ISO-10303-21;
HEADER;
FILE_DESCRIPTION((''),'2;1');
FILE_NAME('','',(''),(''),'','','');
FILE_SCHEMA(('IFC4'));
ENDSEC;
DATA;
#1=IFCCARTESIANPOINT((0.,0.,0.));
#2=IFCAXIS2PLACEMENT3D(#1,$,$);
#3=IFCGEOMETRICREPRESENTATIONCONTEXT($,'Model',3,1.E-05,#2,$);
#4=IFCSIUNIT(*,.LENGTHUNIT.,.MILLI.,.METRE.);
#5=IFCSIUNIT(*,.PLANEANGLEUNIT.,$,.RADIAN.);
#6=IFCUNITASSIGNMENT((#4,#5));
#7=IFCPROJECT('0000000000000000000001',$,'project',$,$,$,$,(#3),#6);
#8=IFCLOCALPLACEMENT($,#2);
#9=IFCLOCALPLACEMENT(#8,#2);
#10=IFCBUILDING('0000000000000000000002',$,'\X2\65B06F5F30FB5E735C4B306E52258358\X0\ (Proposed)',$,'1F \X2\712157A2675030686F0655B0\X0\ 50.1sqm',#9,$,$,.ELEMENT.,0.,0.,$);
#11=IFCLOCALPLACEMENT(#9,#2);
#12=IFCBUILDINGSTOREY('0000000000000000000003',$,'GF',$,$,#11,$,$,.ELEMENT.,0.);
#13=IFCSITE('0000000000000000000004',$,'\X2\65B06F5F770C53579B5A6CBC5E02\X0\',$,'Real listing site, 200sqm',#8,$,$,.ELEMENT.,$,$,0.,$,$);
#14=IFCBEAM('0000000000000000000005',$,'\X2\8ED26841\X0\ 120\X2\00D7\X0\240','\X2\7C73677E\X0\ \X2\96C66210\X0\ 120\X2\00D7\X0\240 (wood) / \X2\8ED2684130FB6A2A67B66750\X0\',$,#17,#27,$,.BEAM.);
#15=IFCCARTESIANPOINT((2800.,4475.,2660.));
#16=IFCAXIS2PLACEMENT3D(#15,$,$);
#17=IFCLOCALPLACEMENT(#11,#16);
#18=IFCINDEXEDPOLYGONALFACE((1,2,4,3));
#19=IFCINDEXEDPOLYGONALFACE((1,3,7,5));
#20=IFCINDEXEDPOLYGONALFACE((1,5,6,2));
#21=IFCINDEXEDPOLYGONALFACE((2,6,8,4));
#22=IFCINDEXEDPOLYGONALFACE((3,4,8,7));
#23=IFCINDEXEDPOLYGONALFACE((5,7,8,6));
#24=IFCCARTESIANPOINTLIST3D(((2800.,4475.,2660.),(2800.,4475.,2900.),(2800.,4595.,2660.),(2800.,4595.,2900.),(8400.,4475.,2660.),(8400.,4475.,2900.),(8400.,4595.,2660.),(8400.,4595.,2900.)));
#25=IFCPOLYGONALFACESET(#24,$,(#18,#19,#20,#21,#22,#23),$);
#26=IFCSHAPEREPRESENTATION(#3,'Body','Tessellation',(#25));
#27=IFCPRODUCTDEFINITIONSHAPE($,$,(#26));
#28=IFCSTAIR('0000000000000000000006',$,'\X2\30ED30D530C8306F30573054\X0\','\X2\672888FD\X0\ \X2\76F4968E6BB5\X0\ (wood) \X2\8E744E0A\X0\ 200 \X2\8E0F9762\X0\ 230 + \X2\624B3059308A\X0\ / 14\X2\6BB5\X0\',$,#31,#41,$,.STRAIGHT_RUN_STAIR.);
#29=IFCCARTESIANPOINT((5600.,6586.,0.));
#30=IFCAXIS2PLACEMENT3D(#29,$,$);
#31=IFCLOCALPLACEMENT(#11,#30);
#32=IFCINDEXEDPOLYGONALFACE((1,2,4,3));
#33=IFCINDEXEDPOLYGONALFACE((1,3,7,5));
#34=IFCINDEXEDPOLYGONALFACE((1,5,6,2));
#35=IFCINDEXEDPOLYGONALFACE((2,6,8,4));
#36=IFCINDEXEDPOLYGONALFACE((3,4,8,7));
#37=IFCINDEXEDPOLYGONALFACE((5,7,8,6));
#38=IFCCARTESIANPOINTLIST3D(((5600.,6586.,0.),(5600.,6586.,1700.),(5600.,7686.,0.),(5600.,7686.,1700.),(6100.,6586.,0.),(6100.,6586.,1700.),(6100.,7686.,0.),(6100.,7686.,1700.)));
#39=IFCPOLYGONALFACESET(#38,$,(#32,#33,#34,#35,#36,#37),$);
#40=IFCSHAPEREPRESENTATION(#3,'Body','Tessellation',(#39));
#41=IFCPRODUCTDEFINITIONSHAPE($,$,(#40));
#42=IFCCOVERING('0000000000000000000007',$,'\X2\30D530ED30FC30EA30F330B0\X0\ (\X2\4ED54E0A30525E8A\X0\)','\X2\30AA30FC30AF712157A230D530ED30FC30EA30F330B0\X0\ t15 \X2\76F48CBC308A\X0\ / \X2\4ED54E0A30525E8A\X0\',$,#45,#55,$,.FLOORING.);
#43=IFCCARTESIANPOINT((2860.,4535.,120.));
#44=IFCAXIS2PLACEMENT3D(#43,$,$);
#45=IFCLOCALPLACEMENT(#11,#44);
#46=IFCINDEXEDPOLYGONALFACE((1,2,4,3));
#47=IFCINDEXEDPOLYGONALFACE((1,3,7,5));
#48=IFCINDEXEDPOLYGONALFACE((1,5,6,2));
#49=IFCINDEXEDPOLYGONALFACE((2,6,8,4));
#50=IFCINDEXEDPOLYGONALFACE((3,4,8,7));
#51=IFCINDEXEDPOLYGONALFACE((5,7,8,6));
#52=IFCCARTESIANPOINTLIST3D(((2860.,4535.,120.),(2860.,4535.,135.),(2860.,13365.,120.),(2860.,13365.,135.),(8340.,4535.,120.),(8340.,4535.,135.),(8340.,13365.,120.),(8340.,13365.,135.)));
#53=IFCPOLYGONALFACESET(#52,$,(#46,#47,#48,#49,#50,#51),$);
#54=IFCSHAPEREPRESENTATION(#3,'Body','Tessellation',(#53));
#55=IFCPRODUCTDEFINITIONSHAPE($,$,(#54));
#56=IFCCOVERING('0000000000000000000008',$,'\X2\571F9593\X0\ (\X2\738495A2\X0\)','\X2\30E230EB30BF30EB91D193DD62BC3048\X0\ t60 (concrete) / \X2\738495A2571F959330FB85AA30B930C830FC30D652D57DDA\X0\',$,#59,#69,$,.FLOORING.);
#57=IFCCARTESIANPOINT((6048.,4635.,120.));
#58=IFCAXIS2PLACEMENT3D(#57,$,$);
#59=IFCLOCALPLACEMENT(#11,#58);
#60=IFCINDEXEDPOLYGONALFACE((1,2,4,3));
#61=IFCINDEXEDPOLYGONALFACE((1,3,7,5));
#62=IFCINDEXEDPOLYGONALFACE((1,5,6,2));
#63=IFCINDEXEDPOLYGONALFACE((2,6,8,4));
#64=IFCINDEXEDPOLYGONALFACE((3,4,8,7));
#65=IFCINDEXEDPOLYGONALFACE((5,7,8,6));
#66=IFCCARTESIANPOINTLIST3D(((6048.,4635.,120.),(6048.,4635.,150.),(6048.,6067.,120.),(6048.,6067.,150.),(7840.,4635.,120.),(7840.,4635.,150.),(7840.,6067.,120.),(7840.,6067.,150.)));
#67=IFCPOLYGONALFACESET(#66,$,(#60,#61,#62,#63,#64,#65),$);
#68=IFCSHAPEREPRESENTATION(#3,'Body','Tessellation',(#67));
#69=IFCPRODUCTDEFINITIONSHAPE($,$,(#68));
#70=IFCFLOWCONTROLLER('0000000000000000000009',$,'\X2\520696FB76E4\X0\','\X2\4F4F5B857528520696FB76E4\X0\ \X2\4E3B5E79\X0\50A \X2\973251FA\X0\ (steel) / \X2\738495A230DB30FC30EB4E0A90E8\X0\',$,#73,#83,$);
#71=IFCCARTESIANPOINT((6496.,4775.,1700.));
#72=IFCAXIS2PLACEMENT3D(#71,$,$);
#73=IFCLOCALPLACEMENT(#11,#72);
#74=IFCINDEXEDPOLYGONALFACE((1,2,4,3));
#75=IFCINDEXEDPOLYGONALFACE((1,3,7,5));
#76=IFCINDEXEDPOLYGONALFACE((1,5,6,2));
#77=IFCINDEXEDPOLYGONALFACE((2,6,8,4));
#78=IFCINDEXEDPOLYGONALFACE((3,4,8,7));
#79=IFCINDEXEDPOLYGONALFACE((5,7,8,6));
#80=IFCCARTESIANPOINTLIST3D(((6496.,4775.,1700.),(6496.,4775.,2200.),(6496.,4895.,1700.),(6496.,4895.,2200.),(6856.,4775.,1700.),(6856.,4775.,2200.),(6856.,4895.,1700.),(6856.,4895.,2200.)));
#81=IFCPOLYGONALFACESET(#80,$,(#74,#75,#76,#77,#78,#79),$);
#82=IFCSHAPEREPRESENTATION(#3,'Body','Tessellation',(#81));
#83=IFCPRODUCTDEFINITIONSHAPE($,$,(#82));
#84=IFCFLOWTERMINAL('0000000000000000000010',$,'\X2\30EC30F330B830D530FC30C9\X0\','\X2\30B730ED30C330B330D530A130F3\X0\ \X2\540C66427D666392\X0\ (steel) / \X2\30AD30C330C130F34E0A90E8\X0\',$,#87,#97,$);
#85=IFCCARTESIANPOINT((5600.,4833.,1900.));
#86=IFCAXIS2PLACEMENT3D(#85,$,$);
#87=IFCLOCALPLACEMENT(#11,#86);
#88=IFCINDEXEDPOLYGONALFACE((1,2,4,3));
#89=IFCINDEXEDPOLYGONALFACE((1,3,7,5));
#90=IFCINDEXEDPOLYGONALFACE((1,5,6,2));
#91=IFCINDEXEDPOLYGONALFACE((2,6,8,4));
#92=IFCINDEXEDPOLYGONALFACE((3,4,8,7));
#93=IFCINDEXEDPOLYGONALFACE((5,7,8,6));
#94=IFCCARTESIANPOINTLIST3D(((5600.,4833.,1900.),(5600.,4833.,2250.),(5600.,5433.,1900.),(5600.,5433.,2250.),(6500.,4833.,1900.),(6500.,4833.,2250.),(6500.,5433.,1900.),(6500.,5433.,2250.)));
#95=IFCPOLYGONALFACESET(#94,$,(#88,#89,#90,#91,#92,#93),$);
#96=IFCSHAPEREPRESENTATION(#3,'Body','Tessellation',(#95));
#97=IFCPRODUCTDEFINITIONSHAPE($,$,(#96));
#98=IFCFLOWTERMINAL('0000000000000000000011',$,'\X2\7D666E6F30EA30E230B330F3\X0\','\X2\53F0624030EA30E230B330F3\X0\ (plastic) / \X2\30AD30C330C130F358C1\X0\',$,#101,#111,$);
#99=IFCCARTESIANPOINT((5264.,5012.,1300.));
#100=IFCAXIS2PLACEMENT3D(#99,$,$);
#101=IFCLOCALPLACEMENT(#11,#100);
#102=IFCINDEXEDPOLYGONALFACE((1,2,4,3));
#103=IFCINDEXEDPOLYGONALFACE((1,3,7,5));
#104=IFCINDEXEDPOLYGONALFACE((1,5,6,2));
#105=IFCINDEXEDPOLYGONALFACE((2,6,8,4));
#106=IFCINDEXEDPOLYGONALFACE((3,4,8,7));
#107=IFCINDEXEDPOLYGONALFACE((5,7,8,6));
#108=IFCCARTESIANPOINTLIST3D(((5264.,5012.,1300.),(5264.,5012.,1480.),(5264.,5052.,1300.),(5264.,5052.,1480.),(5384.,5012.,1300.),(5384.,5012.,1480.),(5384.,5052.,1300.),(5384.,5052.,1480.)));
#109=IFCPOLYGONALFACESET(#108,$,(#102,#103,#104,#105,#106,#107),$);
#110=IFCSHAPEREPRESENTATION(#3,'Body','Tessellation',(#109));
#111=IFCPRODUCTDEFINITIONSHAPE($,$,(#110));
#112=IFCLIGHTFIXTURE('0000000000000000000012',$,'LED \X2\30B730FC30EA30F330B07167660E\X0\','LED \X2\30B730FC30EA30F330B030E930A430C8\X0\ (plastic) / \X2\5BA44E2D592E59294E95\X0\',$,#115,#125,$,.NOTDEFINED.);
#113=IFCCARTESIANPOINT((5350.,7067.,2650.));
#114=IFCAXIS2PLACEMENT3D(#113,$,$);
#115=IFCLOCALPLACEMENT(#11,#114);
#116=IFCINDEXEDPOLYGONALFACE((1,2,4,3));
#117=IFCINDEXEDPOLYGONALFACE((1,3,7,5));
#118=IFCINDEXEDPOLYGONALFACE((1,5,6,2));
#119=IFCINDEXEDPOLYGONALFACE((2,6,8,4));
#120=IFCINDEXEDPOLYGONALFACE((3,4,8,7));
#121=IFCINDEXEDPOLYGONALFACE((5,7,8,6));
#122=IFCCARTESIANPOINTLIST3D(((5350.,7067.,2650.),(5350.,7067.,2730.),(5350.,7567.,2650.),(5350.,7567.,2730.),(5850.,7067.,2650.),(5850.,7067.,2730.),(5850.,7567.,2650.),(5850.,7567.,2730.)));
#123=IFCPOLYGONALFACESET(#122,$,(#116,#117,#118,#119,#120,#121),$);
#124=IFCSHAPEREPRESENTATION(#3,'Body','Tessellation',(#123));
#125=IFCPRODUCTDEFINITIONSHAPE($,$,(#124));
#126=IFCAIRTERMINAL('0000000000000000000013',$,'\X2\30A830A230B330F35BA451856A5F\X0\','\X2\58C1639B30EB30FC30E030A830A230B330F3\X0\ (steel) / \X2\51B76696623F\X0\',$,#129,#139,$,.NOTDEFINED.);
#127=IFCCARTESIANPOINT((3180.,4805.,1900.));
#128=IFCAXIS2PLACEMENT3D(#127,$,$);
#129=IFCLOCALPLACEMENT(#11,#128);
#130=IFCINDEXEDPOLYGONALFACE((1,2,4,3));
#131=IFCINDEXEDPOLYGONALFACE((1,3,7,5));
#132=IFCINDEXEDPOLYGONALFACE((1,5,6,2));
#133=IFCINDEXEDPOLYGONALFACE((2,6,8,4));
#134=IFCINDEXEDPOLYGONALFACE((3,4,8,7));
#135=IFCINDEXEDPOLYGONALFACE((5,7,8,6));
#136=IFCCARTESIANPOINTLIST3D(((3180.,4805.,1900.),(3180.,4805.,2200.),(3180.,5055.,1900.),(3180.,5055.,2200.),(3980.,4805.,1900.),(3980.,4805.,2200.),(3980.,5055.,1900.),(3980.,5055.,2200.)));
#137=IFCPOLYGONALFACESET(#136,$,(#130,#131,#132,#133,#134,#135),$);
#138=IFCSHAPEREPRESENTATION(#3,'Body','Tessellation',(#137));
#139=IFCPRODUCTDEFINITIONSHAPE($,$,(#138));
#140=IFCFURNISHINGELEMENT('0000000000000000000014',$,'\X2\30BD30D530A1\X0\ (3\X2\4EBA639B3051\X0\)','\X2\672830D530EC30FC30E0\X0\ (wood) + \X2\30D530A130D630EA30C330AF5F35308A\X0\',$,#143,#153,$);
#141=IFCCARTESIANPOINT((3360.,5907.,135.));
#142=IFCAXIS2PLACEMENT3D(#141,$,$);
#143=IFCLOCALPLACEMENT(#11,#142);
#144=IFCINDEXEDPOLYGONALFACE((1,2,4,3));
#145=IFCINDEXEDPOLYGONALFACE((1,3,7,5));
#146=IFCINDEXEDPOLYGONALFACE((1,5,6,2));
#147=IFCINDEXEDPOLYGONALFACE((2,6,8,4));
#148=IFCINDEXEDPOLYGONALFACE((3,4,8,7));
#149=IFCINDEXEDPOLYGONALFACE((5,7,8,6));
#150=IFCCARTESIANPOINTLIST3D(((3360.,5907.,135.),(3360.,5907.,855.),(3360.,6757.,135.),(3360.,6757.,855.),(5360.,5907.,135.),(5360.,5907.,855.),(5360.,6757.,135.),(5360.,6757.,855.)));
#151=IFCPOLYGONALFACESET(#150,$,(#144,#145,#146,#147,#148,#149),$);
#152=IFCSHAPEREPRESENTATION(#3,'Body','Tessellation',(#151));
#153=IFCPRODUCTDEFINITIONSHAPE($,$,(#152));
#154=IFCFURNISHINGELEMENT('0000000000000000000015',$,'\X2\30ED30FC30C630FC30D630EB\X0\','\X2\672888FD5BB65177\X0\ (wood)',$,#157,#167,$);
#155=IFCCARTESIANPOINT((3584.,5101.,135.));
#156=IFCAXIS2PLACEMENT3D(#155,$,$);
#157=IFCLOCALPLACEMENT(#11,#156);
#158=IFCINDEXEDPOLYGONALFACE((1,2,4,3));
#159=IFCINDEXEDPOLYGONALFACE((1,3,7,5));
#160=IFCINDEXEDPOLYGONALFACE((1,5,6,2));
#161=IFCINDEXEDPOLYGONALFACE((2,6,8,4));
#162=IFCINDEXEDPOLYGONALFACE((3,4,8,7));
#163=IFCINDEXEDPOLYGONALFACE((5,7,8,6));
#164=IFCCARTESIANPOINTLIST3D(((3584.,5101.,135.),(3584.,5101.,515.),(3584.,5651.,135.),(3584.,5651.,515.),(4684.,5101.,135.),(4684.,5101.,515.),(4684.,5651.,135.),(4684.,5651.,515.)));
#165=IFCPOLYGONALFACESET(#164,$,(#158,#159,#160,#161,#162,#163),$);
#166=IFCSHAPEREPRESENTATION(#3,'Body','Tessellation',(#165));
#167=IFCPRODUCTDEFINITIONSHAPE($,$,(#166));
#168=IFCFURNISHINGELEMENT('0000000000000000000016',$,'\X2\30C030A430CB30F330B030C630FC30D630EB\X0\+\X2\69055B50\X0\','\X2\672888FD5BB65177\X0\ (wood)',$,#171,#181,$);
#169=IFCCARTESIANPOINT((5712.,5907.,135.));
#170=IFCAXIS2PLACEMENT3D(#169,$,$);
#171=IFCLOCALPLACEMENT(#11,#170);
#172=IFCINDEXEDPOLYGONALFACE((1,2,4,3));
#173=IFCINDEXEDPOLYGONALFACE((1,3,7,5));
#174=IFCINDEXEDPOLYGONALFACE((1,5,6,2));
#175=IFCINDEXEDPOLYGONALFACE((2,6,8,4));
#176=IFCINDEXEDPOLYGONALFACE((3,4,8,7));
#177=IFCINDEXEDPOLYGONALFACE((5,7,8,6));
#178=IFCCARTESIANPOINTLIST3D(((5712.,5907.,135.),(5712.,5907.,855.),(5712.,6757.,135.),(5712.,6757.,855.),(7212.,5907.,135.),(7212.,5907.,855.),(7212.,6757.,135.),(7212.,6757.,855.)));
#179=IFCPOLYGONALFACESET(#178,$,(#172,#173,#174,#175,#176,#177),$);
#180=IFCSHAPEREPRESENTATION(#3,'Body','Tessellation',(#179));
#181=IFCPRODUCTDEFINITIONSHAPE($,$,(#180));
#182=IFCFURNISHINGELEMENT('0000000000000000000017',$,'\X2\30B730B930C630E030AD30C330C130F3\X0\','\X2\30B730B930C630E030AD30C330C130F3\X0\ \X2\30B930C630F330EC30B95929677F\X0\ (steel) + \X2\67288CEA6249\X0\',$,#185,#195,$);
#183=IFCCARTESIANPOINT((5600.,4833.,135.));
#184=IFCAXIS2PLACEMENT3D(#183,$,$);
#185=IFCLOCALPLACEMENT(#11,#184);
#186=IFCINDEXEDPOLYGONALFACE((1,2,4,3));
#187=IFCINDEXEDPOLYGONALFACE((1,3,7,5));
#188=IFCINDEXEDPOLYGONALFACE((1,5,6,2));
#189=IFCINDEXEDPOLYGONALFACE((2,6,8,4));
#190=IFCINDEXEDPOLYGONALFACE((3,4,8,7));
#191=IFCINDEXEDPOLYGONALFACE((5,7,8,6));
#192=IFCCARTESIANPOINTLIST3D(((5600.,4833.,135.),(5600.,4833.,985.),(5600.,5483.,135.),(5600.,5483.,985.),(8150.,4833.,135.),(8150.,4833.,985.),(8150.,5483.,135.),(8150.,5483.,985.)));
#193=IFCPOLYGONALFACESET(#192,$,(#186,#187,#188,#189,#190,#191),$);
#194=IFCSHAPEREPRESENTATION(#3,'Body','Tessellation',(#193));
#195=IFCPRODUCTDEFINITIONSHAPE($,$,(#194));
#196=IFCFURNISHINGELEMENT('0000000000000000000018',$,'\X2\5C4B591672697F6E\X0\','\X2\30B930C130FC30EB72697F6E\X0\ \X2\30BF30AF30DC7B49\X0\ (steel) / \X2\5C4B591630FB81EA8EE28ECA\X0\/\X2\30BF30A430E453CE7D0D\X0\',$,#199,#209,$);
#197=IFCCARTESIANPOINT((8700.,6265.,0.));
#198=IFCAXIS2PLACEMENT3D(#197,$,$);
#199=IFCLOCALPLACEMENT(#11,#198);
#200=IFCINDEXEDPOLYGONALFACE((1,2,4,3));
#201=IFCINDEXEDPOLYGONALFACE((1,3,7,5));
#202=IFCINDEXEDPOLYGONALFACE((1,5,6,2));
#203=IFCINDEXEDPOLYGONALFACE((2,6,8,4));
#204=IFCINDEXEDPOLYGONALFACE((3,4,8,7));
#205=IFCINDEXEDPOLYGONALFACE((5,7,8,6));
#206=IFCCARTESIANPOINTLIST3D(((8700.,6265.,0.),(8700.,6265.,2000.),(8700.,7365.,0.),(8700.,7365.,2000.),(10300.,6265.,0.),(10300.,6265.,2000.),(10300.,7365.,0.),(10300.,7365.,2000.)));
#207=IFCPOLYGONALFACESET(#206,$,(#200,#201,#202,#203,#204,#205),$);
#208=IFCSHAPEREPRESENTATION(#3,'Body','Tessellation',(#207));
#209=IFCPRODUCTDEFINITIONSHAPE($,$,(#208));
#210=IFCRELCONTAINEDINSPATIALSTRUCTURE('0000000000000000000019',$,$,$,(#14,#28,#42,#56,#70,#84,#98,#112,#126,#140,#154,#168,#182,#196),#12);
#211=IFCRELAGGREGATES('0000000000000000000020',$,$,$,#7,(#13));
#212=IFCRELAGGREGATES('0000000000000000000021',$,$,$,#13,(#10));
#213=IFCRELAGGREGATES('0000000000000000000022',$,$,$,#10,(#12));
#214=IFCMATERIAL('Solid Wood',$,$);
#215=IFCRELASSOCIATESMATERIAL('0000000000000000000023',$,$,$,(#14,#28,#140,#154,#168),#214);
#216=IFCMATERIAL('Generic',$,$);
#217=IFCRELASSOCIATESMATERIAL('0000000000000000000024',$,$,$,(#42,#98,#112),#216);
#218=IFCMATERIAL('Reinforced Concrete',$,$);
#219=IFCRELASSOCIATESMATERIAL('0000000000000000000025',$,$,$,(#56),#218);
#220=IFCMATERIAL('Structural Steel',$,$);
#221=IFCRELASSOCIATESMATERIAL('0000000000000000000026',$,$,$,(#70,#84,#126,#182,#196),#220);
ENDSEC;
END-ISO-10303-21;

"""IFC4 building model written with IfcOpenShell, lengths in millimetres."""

from ifc_helpers import new_model, si_unit, frame, frame_2d, origin, place, context, project, spatial, rectangle, extrude, material, element, save


model = new_model("IFC4")

# Units and contexts
model_context = context("Model", 3, precision=1e-05, world=origin())
ifc_project = project(units=[si_unit("LENGTHUNIT", "METRE", prefix="MILLI"), si_unit("PLANEANGLEUNIT", "RADIAN")], contexts=[model_context])

# Site, building, storey
site_placement = place(None, origin())
site = spatial("IfcSite", under=ifc_project, at=site_placement, Name="新潟県南魚沼市", ObjectType="Real listing site, 200sqm", CompositionType="ELEMENT", RefElevation=0.0)
building_placement = place(site_placement, origin())
building = spatial("IfcBuilding", under=site, at=building_placement, Name="新潟・平屋の別荘 (Proposed)", ObjectType="1F 無垢材と漆喰 50.1sqm", CompositionType="ELEMENT", ElevationOfRefHeight=0.0, ElevationOfTerrain=0.0)
storey_placement = place(building_placement, origin())
storey = spatial("IfcBuildingStorey", under=building, at=storey_placement, Name="GF", CompositionType="ELEMENT", Elevation=0.0)

# Beam
ifc_material_1 = material(Name="Solid Wood")
beam_1_placement = place(storey_placement, frame((2800.0, 4475.0, 2660.0)))
element("IfcBeam", 1, at=beam_1_placement, inside=storey, material=ifc_material_1, Name="軒桁 120×240", Description="米松 集成 120×240 (wood) / 軒桁・横架材", PredefinedType="BEAM", context=model_context, shape_type="SweptSolid", body=[
    extrude(rectangle(XDim=5600.0, YDim=120.0, at=frame_2d((2800.0, 60.0))), frame((2800.0, 4475.0, 2660.0)), (0.0, 0.0, 1.0), 240.0),
])

# Stair
stair_placement = place(storey_placement, frame((5600.0, 6586.0, 0.0)))
element("IfcStair", 2, at=stair_placement, inside=storey, material=ifc_material_1, Name="ロフトはしご", Description="木製 直階段 (wood) 蹴上 200 踏面 230 + 手すり / 14段", PredefinedType="STRAIGHT_RUN_STAIR", context=model_context, shape_type="SweptSolid", body=[
    extrude(rectangle(XDim=500.0, YDim=1100.0, at=frame_2d((250.0, 550.0))), frame((5600.0, 6586.0, 0.0)), (0.0, 0.0, 1.0), 1700.0),
])

# Coverings
ifc_material_2 = material(Name="Generic")
covering_1_placement = place(storey_placement, frame((2860.0, 4535.0, 120.0)))
element("IfcCovering", 3, at=covering_1_placement, inside=storey, material=ifc_material_2, Name="フローリング (仕上げ床)", Description="オーク無垢フローリング t15 直貼り / 仕上げ床", PredefinedType="FLOORING", context=model_context, shape_type="SweptSolid", body=[
    extrude(rectangle(XDim=5480.0, YDim=8830.0, at=frame_2d((2740.0, 4415.0))), frame((2860.0, 4535.0, 120.0)), (0.0, 0.0, 1.0), 15.0),
])
ifc_material_3 = material(Name="Reinforced Concrete")
covering_2_placement = place(storey_placement, frame((6048.0, 4635.0, 120.0)))
element("IfcCovering", 4, at=covering_2_placement, inside=storey, material=ifc_material_3, Name="土間 (玄関)", Description="モルタル金鏝押え t60 (concrete) / 玄関土間・薪ストーブ動線", PredefinedType="FLOORING", context=model_context, shape_type="SweptSolid", body=[
    extrude(rectangle(XDim=1792.0, YDim=1432.0, at=frame_2d((896.0, 716.0))), frame((6048.0, 4635.0, 120.0)), (0.0, 0.0, 1.0), 30.0),
])

# Flow controller
ifc_material_4 = material(Name="Structural Steel")
flow_controller_placement = place(storey_placement, frame((6496.0, 4775.0, 1700.0)))
element("IfcFlowController", 5, at=flow_controller_placement, inside=storey, material=ifc_material_4, Name="分電盤", Description="住宅用分電盤 主幹50A 露出 (steel) / 玄関ホール上部", context=model_context, shape_type="SweptSolid", body=[
    extrude(rectangle(XDim=360.0, YDim=120.0, at=frame_2d((180.0, 60.0))), frame((6496.0, 4775.0, 1700.0)), (0.0, 0.0, 1.0), 500.0),
])

# Flow terminals
flow_terminal_1_placement = place(storey_placement, frame((5600.0, 4833.0, 1900.0)))
element("IfcFlowTerminal", 6, at=flow_terminal_1_placement, inside=storey, material=ifc_material_4, Name="レンジフード", Description="シロッコファン 同時給排 (steel) / キッチン上部", context=model_context, shape_type="SweptSolid", body=[
    extrude(rectangle(XDim=900.0, YDim=600.0, at=frame_2d((450.0, 300.0))), frame((5600.0, 4833.0, 1900.0)), (0.0, 0.0, 1.0), 350.0),
])
flow_terminal_2_placement = place(storey_placement, frame((5264.0, 5012.0, 1300.0)))
element("IfcFlowTerminal", 7, at=flow_terminal_2_placement, inside=storey, material=ifc_material_2, Name="給湯リモコン", Description="台所リモコン (plastic) / キッチン壁", context=model_context, shape_type="SweptSolid", body=[
    extrude(rectangle(XDim=120.0, YDim=40.0, at=frame_2d((60.0, 20.0))), frame((5264.0, 5012.0, 1300.0)), (0.0, 0.0, 1.0), 180.0),
])

# Light fixture
light_fixture_placement = place(storey_placement, frame((5350.0, 7067.0, 2650.0)))
element("IfcLightFixture", 8, at=light_fixture_placement, inside=storey, material=ifc_material_2, Name="LED シーリング照明", Description="LED シーリングライト (plastic) / 室中央天井", PredefinedType="NOTDEFINED", context=model_context, shape_type="SweptSolid", body=[
    extrude(rectangle(XDim=500.0, YDim=500.0, at=frame_2d((250.0, 250.0))), frame((5350.0, 7067.0, 2650.0)), (0.0, 0.0, 1.0), 80.0),
])

# Air terminal
air_terminal_placement = place(storey_placement, frame((3180.0, 4805.0, 1900.0)))
element("IfcAirTerminal", 9, at=air_terminal_placement, inside=storey, material=ifc_material_4, Name="エアコン室内機", Description="壁掛ルームエアコン (steel) / 冷暖房", PredefinedType="NOTDEFINED", context=model_context, shape_type="SweptSolid", body=[
    extrude(rectangle(XDim=800.0, YDim=250.0, at=frame_2d((400.0, 125.0))), frame((3180.0, 4805.0, 1900.0)), (0.0, 0.0, 1.0), 300.0),
])

# Furnishing elements
furnishing_1_placement = place(storey_placement, frame((3360.0, 5907.0, 135.0)))
element("IfcFurnishingElement", 10, at=furnishing_1_placement, inside=storey, material=ifc_material_1, Name="ソファ (3人掛け)", Description="木フレーム (wood) + ファブリック張り", context=model_context, shape_type="SweptSolid", body=[
    extrude(rectangle(XDim=2000.0, YDim=850.0, at=frame_2d((1000.0, 425.0))), frame((3360.0, 5907.0, 135.0)), (0.0, 0.0, 1.0), 720.0),
])
furnishing_2_placement = place(storey_placement, frame((3584.0, 5101.0, 135.0)))
element("IfcFurnishingElement", 11, at=furnishing_2_placement, inside=storey, material=ifc_material_1, Name="ローテーブル", Description="木製家具 (wood)", context=model_context, shape_type="SweptSolid", body=[
    extrude(rectangle(XDim=1100.0, YDim=550.0, at=frame_2d((550.0, 275.0))), frame((3584.0, 5101.0, 135.0)), (0.0, 0.0, 1.0), 380.0),
])
furnishing_3_placement = place(storey_placement, frame((5712.0, 5907.0, 135.0)))
element("IfcFurnishingElement", 12, at=furnishing_3_placement, inside=storey, material=ifc_material_1, Name="ダイニングテーブル+椅子", Description="木製家具 (wood)", context=model_context, shape_type="SweptSolid", body=[
    extrude(rectangle(XDim=1500.0, YDim=850.0, at=frame_2d((750.0, 425.0))), frame((5712.0, 5907.0, 135.0)), (0.0, 0.0, 1.0), 720.0),
])
furnishing_4_placement = place(storey_placement, frame((5600.0, 4833.0, 135.0)))
element("IfcFurnishingElement", 13, at=furnishing_4_placement, inside=storey, material=ifc_material_4, Name="システムキッチン", Description="システムキッチン ステンレス天板 (steel) + 木質扉", context=model_context, shape_type="SweptSolid", body=[
    extrude(rectangle(XDim=2550.0, YDim=650.0, at=frame_2d((1275.0, 325.0))), frame((5600.0, 4833.0, 135.0)), (0.0, 0.0, 1.0), 850.0),
])
furnishing_5_placement = place(storey_placement, frame((8700.0, 6265.0, 0.0)))
element("IfcFurnishingElement", 14, at=furnishing_5_placement, inside=storey, material=ifc_material_4, Name="屋外物置", Description="スチール物置 タクボ等 (steel) / 屋外・自転車/タイヤ収納", context=model_context, shape_type="SweptSolid", body=[
    extrude(rectangle(XDim=1600.0, YDim=1100.0, at=frame_2d((800.0, 550.0))), frame((8700.0, 6265.0, 0.0)), (0.0, 0.0, 1.0), 2000.0),
])

save(model, "model.ifc")
